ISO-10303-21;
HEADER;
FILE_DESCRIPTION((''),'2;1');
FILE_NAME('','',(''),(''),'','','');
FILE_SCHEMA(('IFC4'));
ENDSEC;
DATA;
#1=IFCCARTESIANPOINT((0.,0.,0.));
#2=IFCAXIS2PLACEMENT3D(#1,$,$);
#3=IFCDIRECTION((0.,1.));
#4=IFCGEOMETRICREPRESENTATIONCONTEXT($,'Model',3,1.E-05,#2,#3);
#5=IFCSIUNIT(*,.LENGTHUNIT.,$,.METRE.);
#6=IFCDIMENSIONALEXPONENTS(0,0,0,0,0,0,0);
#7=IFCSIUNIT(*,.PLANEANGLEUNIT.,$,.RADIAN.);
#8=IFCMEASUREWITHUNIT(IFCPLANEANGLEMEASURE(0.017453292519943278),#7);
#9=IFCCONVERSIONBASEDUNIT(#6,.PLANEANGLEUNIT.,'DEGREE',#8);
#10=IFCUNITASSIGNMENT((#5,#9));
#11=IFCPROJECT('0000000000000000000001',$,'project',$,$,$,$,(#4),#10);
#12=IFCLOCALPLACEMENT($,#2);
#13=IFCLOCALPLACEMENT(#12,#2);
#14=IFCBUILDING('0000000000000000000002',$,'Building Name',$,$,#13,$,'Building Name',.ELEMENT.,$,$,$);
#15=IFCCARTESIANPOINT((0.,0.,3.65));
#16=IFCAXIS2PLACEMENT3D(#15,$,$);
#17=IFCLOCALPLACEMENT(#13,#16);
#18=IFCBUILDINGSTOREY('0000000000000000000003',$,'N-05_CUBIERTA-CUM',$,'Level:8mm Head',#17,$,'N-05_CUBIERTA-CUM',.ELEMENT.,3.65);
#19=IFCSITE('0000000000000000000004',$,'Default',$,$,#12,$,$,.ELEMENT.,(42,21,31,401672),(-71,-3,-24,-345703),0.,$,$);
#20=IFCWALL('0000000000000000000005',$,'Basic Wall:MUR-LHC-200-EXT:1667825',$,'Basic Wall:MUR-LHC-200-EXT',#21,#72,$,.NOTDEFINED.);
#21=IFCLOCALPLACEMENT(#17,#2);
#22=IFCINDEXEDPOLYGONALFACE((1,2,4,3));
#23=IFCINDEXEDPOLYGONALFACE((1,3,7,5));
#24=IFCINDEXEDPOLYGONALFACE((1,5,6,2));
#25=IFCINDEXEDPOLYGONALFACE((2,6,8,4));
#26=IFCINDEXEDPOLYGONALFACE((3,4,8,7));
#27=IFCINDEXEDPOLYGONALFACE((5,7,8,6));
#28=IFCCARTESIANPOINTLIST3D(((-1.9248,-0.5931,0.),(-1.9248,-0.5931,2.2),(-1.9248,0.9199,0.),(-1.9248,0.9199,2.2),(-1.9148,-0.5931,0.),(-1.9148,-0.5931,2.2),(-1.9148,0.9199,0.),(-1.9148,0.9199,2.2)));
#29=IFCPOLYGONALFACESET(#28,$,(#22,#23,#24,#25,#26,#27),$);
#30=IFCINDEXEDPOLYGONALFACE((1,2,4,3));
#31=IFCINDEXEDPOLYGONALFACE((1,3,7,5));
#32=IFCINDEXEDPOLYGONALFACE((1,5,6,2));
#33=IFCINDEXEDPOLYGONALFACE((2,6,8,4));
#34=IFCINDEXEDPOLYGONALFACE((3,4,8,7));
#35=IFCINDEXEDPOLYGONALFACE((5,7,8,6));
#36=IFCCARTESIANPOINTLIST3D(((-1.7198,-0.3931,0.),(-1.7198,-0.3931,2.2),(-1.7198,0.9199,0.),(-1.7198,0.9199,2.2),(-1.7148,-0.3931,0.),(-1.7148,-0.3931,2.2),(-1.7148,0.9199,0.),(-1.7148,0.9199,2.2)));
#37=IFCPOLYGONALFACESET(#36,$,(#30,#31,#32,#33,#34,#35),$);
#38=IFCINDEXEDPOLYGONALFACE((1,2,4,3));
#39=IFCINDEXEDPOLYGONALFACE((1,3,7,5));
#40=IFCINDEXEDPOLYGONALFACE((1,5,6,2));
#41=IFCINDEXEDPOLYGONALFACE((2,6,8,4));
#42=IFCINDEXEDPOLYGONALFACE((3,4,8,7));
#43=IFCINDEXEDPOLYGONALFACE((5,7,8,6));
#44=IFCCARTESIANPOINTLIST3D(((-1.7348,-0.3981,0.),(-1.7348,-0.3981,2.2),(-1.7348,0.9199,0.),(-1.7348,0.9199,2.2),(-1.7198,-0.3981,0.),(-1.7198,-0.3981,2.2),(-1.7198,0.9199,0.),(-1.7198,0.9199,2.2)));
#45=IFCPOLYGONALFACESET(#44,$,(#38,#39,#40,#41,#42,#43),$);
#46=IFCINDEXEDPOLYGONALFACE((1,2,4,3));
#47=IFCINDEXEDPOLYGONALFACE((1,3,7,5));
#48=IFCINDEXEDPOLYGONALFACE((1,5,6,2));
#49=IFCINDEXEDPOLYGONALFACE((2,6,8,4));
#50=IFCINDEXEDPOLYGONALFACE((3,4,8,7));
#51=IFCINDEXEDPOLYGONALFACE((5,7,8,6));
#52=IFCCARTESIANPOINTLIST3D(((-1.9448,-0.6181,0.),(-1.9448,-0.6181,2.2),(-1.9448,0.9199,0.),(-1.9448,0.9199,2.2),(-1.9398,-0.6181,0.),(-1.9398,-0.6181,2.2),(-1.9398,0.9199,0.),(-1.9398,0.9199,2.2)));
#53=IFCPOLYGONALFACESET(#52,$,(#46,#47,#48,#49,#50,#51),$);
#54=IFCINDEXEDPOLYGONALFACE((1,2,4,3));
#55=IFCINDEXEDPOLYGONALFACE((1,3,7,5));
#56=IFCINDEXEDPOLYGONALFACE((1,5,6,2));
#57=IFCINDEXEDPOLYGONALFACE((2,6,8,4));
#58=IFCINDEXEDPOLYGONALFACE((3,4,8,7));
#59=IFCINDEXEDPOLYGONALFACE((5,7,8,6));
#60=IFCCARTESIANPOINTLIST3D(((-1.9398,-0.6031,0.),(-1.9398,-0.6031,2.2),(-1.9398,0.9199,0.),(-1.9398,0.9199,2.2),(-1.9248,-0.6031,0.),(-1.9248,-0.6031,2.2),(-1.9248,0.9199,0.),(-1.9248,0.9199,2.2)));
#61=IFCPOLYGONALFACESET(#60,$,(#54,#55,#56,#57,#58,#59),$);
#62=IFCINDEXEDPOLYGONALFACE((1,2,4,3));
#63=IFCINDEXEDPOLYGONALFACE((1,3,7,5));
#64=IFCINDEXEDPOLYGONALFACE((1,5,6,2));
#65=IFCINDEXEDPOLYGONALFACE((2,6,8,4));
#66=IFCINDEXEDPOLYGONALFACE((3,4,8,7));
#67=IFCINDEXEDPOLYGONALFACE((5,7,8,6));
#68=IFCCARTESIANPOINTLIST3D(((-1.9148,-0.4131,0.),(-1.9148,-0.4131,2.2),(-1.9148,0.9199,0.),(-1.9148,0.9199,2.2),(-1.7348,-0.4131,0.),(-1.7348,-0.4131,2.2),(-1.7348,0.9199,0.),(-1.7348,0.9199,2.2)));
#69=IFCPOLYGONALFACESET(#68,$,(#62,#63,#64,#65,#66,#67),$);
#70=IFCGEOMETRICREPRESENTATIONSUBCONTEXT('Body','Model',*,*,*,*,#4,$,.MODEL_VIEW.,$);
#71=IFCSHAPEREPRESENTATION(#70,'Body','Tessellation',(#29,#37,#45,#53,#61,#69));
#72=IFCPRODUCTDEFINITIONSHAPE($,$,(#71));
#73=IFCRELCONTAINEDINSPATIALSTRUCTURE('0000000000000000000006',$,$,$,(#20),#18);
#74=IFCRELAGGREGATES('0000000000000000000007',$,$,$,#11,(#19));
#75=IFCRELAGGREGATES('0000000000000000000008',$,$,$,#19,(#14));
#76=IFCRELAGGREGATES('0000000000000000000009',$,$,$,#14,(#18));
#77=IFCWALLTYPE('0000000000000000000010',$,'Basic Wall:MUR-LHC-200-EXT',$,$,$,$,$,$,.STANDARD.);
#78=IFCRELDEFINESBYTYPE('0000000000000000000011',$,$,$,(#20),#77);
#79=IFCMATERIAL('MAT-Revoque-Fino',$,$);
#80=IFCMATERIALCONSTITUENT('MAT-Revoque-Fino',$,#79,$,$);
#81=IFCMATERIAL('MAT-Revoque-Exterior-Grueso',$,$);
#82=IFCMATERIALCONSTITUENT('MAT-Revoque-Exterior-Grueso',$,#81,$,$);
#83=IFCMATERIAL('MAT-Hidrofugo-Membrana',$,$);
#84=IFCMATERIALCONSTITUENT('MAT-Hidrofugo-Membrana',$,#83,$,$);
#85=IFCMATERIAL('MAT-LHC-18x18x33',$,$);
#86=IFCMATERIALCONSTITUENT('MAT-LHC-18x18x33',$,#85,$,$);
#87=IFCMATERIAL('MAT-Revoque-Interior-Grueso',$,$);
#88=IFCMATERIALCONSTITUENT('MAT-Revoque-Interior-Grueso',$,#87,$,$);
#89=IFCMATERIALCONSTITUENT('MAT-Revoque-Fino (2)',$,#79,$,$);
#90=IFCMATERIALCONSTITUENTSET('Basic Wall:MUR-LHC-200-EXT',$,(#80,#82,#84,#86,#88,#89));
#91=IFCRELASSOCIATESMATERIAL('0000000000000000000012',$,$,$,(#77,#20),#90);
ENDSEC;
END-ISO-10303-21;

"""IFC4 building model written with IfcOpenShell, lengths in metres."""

from ifc_helpers import new_model, entity, si_unit, converted_unit, direction, frame, origin, place, context, subcontext, project, spatial, indexed_curve, outline, extrude, material, constituent, constituent_set, type_object, element, save


model = new_model("IFC4")

# Units and contexts
model_context = context("Model", 3, precision=1e-05, world=origin(), true_north=direction((0.0, 1.0)))
body_context = subcontext(model_context, "Body", "Model", "MODEL_VIEW")
ifc_project = project(units=[si_unit("LENGTHUNIT", "METRE"), converted_unit("PLANEANGLEUNIT", "DEGREE", entity("IfcPlaneAngleMeasure", 0.017453292519943278), si_unit("PLANEANGLEUNIT", "RADIAN"), dimensions=[0, 0, 0, 0, 0, 0, 0])], contexts=[model_context])

# Site, building, storey
site_placement = place(None, origin())
site = spatial("IfcSite", under=ifc_project, at=site_placement, Name="Default", CompositionType="ELEMENT", RefLatitude=(42, 21, 31, 401672), RefLongitude=(-71, -3, -24, -345703), RefElevation=0.0)
building_placement = place(site_placement, origin())
building = spatial("IfcBuilding", under=site, at=building_placement, Name="Building Name", LongName="Building Name", CompositionType="ELEMENT")
storey_placement = place(building_placement, frame((0.0, 0.0, 3.65)))
storey = spatial("IfcBuildingStorey", under=building, at=storey_placement, Name="N-05_CUBIERTA-CUM", ObjectType="Level:8mm Head", LongName="N-05_CUBIERTA-CUM", CompositionType="ELEMENT", Elevation=3.65)

# Wall
ifc_material_1 = material(Name="MAT-Revoque-Fino")
ifc_constituent_1 = constituent(ifc_material_1, Name="MAT-Revoque-Fino")
ifc_material_2 = material(Name="MAT-Revoque-Exterior-Grueso")
ifc_constituent_2 = constituent(ifc_material_2, Name="MAT-Revoque-Exterior-Grueso")
ifc_material_3 = material(Name="MAT-Hidrofugo-Membrana")
ifc_constituent_3 = constituent(ifc_material_3, Name="MAT-Hidrofugo-Membrana")
ifc_material_4 = material(Name="MAT-LHC-18x18x33")
ifc_constituent_4 = constituent(ifc_material_4, Name="MAT-LHC-18x18x33")
ifc_material_5 = material(Name="MAT-Revoque-Interior-Grueso")
ifc_constituent_5 = constituent(ifc_material_5, Name="MAT-Revoque-Interior-Grueso")
ifc_constituent_6 = constituent(ifc_material_1, Name="MAT-Revoque-Fino (2)")
ifc_constituent_set = constituent_set(constituents=[ifc_constituent_1, ifc_constituent_2, ifc_constituent_3, ifc_constituent_4, ifc_constituent_5, ifc_constituent_6], Name="Basic Wall:MUR-LHC-200-EXT")
wall_type = type_object("IfcWallType", Name="Basic Wall:MUR-LHC-200-EXT", PredefinedType="STANDARD", material=ifc_constituent_set)
wall_placement = place(storey_placement, frame((-1.8298, -0.3931, 0.0), z_axis=(0.0, 0.0, 1.0), x_axis=(0.0, 1.0, 0.0)))
element("IfcWall", 1, at=wall_placement, inside=storey, type_object=wall_type, material=ifc_constituent_set, Name="Basic Wall:MUR-LHC-200-EXT:1667825", ObjectType="Basic Wall:MUR-LHC-200-EXT", PredefinedType="NOTDEFINED", context=body_context, shape_type="SweptSolid", body=[
    extrude(outline(indexed_curve([(-0.005, -0.7565), (0.005, -0.7565), (0.005, 0.7565), (-0.005, 0.7565), (-0.005, -0.7565)], self_intersect=False)), frame((0.5565, 0.09, 0.0), z_axis=(0.0, 0.0, 1.0), x_axis=(0.0, -1.0, 0.0)), (0.0, 0.0, 1.0), 2.2),
    extrude(outline(indexed_curve([(-0.0025, -0.6565), (0.0025, -0.6565), (0.0025, 0.6565), (-0.0025, 0.6565), (-0.0025, -0.6565)], self_intersect=False)), frame((0.6565, -0.1125, 0.0), z_axis=(0.0, 0.0, 1.0), x_axis=(0.0, -1.0, 0.0)), (0.0, 0.0, 1.0), 2.2),
    extrude(outline(indexed_curve([(-0.0075, -0.659), (0.0075, -0.659), (0.0075, 0.659), (-0.0075, 0.659), (-0.0075, -0.659)], self_intersect=False)), frame((0.654, -0.1025, 0.0), z_axis=(0.0, 0.0, 1.0), x_axis=(0.0, 1.0, 0.0)), (0.0, 0.0, 1.0), 2.2),
    extrude(outline(indexed_curve([(-0.0025, -0.769), (0.0025, -0.769), (0.0025, 0.769), (-0.0025, 0.769), (-0.0025, -0.769)], self_intersect=False)), frame((0.544, 0.1125, 0.0), z_axis=(0.0, 0.0, 1.0), x_axis=(0.0, 1.0, 0.0)), (0.0, 0.0, 1.0), 2.2),
    extrude(outline(indexed_curve([(-0.0075, -0.7615), (0.0075, -0.7615), (0.0075, 0.7615), (-0.0075, 0.7615), (-0.0075, -0.7615)], self_intersect=False)), frame((0.5515, 0.1025, 0.0), z_axis=(0.0, 0.0, 1.0), x_axis=(0.0, 1.0, 0.0)), (0.0, 0.0, 1.0), 2.2),
    extrude(outline(indexed_curve([(-0.09, -0.6665), (0.09, -0.6665), (0.09, 0.6665), (-0.09, 0.6665), (-0.09, -0.6665)], self_intersect=False)), frame((0.6465, -0.005, 0.0), z_axis=(0.0, 0.0, 1.0), x_axis=(0.0, -1.0, 0.0)), (0.0, 0.0, 1.0), 2.2),
])

save(model, "model.ifc")
